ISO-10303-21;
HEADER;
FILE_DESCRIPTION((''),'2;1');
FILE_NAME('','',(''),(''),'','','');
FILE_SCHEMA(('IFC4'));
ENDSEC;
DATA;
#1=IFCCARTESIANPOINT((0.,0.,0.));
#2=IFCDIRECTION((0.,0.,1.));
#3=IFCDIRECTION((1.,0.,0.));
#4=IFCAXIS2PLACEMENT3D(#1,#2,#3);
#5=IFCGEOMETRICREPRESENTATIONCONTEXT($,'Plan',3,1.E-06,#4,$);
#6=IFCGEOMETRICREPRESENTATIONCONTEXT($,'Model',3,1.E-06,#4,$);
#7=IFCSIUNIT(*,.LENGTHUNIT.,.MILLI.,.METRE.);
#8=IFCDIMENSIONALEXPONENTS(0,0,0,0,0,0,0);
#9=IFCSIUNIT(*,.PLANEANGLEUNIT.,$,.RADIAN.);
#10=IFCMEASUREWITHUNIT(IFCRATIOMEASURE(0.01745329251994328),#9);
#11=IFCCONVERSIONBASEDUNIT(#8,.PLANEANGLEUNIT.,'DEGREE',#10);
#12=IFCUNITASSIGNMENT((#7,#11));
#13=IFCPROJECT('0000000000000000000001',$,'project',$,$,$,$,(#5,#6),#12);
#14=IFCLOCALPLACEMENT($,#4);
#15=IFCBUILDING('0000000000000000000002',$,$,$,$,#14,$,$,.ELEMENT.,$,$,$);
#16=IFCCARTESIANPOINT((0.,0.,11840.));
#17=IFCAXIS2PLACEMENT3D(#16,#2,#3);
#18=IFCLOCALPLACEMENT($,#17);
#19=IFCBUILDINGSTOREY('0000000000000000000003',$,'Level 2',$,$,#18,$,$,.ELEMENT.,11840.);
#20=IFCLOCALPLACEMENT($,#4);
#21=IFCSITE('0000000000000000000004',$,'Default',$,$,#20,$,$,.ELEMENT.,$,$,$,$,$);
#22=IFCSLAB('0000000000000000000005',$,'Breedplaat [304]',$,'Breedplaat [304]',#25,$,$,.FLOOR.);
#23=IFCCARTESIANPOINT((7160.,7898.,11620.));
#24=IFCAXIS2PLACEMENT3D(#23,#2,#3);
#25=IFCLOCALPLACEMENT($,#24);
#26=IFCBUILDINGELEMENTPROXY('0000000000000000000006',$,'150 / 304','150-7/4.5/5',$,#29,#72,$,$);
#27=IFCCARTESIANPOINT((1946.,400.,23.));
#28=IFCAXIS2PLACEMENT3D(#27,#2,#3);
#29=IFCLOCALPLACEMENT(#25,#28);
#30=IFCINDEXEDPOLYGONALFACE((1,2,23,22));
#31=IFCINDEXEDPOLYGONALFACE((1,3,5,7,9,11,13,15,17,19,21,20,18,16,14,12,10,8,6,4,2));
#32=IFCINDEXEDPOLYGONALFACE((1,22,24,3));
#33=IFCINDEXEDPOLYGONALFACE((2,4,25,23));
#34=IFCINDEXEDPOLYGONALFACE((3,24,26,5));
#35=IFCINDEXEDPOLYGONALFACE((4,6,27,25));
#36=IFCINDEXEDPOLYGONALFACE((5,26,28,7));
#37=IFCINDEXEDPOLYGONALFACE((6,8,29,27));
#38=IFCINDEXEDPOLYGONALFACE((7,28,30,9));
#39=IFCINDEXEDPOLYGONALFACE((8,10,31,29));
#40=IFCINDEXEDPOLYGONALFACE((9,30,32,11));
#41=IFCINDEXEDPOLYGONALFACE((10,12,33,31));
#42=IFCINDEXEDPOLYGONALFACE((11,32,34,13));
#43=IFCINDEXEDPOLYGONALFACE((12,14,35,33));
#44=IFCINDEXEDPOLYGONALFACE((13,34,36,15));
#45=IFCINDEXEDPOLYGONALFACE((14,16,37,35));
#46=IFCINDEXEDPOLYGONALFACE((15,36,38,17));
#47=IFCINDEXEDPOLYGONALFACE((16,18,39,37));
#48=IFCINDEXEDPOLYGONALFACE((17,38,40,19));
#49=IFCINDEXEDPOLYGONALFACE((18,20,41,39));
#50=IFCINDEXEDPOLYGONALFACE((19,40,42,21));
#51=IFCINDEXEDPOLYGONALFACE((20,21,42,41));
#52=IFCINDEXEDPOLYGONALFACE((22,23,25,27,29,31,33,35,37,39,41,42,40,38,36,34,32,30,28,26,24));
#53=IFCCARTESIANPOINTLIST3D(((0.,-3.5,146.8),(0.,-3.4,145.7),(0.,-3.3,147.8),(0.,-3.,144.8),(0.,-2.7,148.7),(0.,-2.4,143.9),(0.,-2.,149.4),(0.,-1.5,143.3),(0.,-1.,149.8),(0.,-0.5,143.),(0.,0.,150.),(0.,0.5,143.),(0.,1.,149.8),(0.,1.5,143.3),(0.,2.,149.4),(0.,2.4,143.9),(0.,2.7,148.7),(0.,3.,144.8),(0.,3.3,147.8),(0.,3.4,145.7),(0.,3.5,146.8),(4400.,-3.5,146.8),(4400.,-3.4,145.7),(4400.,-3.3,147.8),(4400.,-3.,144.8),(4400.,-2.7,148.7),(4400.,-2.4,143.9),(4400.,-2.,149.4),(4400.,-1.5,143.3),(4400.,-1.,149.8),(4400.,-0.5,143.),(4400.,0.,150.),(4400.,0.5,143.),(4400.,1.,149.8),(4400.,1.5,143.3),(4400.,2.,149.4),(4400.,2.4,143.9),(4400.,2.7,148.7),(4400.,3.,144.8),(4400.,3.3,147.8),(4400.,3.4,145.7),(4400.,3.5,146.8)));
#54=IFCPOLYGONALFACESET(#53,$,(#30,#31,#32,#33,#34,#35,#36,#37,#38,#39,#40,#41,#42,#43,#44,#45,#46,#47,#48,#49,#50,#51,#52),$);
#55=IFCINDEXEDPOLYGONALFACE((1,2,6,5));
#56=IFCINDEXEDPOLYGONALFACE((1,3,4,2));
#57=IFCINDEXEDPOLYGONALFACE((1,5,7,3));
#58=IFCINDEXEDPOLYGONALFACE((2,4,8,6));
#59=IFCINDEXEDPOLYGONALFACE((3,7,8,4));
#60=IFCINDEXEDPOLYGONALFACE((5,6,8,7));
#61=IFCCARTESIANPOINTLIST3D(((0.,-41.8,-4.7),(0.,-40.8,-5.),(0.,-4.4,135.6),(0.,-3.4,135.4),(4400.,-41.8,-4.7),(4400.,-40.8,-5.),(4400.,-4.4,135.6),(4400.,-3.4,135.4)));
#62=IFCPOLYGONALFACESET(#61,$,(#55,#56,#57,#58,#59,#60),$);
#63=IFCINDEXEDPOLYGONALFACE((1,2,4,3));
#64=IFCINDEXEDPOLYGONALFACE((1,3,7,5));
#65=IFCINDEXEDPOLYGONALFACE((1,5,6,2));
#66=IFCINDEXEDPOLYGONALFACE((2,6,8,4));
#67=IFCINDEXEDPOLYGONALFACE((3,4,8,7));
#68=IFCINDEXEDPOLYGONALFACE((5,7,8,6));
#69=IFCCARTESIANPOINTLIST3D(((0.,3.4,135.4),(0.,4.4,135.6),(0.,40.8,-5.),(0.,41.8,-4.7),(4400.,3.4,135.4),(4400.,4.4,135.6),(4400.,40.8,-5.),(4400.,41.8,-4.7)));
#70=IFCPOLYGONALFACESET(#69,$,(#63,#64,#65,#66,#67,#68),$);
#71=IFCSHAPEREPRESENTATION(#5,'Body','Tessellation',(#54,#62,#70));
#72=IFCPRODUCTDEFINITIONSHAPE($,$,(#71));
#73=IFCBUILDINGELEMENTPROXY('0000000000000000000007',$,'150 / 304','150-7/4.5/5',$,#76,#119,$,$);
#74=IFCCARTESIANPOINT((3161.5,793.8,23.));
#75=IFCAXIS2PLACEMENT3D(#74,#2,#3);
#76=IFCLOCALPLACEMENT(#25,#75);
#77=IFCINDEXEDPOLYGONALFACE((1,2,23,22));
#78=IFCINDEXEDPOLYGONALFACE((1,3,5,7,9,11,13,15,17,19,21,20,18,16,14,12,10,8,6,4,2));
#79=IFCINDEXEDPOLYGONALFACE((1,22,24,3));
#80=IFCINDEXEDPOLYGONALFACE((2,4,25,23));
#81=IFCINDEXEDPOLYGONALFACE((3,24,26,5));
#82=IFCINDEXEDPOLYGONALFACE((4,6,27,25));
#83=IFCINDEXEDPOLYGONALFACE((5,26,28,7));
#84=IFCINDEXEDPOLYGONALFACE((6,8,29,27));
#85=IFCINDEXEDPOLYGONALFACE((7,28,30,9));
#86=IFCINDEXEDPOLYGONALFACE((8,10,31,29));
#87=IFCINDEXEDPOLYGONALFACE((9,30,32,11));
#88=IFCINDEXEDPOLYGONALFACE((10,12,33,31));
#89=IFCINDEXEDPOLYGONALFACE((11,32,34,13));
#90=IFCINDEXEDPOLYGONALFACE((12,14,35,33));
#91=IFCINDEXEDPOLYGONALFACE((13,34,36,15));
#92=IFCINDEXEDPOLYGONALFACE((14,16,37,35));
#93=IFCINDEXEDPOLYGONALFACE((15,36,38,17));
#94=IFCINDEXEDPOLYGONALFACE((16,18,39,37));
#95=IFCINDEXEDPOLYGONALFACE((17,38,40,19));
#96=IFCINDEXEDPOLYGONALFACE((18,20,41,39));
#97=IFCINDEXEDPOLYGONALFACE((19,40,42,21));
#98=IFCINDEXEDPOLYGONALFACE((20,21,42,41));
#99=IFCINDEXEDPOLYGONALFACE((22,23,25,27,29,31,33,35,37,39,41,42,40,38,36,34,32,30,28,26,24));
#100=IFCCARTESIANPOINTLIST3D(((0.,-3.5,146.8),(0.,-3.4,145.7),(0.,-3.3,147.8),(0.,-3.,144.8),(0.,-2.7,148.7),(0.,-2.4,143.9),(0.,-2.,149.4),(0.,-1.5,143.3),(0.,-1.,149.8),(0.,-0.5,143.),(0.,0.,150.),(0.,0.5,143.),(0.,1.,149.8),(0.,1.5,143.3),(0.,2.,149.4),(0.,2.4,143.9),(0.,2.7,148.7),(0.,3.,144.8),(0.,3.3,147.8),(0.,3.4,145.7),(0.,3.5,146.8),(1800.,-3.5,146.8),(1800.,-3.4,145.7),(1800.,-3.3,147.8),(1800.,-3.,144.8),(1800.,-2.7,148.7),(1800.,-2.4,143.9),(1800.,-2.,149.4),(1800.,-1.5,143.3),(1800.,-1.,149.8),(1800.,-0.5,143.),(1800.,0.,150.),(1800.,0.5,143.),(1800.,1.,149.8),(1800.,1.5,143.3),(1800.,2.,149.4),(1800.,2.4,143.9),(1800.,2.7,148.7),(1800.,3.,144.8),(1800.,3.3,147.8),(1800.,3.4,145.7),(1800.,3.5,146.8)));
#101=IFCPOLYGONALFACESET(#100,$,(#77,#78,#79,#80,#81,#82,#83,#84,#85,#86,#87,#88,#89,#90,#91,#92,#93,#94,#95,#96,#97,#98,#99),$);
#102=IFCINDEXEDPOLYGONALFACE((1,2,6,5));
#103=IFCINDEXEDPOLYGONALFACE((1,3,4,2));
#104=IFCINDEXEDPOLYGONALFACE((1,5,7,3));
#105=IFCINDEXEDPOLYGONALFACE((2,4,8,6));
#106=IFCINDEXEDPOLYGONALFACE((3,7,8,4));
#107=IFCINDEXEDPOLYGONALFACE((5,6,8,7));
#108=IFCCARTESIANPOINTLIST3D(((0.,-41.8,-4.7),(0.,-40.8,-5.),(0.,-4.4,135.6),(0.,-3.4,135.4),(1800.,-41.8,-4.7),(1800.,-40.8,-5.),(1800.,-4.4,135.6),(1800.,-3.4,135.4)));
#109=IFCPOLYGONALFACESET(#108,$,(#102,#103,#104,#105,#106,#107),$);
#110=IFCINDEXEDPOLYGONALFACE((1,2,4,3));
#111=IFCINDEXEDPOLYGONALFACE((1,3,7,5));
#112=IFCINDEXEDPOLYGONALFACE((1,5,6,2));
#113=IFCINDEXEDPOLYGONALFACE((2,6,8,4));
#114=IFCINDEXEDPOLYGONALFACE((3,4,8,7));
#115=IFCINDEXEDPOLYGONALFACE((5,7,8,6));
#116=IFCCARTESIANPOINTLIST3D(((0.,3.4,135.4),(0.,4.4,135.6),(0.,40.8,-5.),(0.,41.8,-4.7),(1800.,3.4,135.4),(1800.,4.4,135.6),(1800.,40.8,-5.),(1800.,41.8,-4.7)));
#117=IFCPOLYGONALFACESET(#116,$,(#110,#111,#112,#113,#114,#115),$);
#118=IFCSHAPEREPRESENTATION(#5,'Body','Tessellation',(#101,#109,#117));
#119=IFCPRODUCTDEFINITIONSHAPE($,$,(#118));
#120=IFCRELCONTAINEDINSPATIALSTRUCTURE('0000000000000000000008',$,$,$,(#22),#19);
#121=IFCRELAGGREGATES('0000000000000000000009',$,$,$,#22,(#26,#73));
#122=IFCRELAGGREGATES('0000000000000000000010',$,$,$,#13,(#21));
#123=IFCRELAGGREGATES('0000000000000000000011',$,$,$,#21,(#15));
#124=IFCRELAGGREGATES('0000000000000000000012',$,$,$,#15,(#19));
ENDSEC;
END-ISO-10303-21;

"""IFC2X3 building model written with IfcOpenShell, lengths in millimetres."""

from ifc_helpers import new_model, entity, si_unit, converted_unit, frame, origin_with_axes, origin_2d_with_axis, place, context, project, spatial, rectangle, circle, extrude, element, aggregate, save


model = new_model("IFC2X3")

# Units and contexts
plan_context = context("Plan", 3, precision=1e-06, world=origin_with_axes())
model_context = context("Model", 3, precision=1e-06, world=origin_with_axes())
ifc_project = project(units=[si_unit("LENGTHUNIT", "METRE", prefix="MILLI"), converted_unit("PLANEANGLEUNIT", "DEGREE", entity("IfcRatioMeasure", 0.01745329251994328), si_unit("PLANEANGLEUNIT", "RADIAN"), dimensions=[0, 0, 0, 0, 0, 0, 0])], contexts=[plan_context, model_context])

# Site, building, storey
site_placement = place(None, origin_with_axes())
site = spatial("IfcSite", under=ifc_project, at=site_placement, Name="Default", CompositionType="ELEMENT")
building_placement = place(None, origin_with_axes())
building = spatial("IfcBuilding", under=site, at=building_placement, CompositionType="ELEMENT")
storey_placement = place(None, frame((0.0, 0.0, 11840.0), z_axis=(0.0, 0.0, 1.0), x_axis=(1.0, 0.0, 0.0)))
storey = spatial("IfcBuildingStorey", under=building, at=storey_placement, Name="Level 2", CompositionType="ELEMENT", Elevation=11840.0)

# Slab, building element proxies
slab_1_placement = place(None, frame((7160.0, 7898.0, 11620.0), z_axis=(0.0, 0.0, 1.0), x_axis=(1.0, 0.0, 0.0)))
slab_1 = element("IfcSlab", 1, at=slab_1_placement, inside=storey, Name="Breedplaat [304]", ObjectType="Breedplaat [304]", PredefinedType="FLOOR")
proxy_1_placement = place(slab_1_placement, frame((1946.0, 400.0, 23.0), z_axis=(0.0, 0.0, 1.0), x_axis=(1.0, 0.0, 0.0)))
proxy_1 = element("IfcBuildingElementProxy", 2, at=proxy_1_placement, Name="150 / 304", Description="150-7/4.5/5", context=plan_context, shape_type="SweptSolid", body=[
    extrude(circle(Radius=3.5, at=origin_2d_with_axis()), frame((0.0, 0.0, 146.5), z_axis=(1.0, 0.0, 0.0), x_axis=(0.0, 0.0, 1.0)), (0.0, 0.0, 1.0), 4400.0),
    extrude(rectangle(XDim=145.2, YDim=1.0, at=origin_2d_with_axis()), frame((0.0, -22.6, 65.3), z_axis=(1.0, 0.0, 0.0), x_axis=(0.0, 0.257663, 0.966235)), (0.0, 0.0, 1.0), 4400.0),
    extrude(rectangle(XDim=145.2, YDim=1.0, at=origin_2d_with_axis()), frame((0.0, 22.6, 65.3), z_axis=(1.0, 0.0, 0.0), x_axis=(0.0, -0.257663, 0.966235)), (0.0, 0.0, 1.0), 4400.0),
])
proxy_2_placement = place(slab_1_placement, frame((3161.5, 793.8, 23.0), z_axis=(0.0, 0.0, 1.0), x_axis=(1.0, 0.0, 0.0)))
proxy_2 = element("IfcBuildingElementProxy", 3, at=proxy_2_placement, Name="150 / 304", Description="150-7/4.5/5", context=plan_context, shape_type="SweptSolid", body=[
    extrude(circle(Radius=3.5, at=origin_2d_with_axis()), frame((0.0, 0.0, 146.5), z_axis=(1.0, 0.0, 0.0), x_axis=(0.0, 0.0, 1.0)), (0.0, 0.0, 1.0), 1800.0),
    extrude(rectangle(XDim=145.2, YDim=1.0, at=origin_2d_with_axis()), frame((0.0, -22.6, 65.3), z_axis=(1.0, 0.0, 0.0), x_axis=(0.0, 0.257663, 0.966235)), (0.0, 0.0, 1.0), 1800.0),
    extrude(rectangle(XDim=145.2, YDim=1.0, at=origin_2d_with_axis()), frame((0.0, 22.6, 65.3), z_axis=(1.0, 0.0, 0.0), x_axis=(0.0, -0.257663, 0.966235)), (0.0, 0.0, 1.0), 1800.0),
])
aggregate(slab_1, [proxy_1, proxy_2])

save(model, "model.ifc")
